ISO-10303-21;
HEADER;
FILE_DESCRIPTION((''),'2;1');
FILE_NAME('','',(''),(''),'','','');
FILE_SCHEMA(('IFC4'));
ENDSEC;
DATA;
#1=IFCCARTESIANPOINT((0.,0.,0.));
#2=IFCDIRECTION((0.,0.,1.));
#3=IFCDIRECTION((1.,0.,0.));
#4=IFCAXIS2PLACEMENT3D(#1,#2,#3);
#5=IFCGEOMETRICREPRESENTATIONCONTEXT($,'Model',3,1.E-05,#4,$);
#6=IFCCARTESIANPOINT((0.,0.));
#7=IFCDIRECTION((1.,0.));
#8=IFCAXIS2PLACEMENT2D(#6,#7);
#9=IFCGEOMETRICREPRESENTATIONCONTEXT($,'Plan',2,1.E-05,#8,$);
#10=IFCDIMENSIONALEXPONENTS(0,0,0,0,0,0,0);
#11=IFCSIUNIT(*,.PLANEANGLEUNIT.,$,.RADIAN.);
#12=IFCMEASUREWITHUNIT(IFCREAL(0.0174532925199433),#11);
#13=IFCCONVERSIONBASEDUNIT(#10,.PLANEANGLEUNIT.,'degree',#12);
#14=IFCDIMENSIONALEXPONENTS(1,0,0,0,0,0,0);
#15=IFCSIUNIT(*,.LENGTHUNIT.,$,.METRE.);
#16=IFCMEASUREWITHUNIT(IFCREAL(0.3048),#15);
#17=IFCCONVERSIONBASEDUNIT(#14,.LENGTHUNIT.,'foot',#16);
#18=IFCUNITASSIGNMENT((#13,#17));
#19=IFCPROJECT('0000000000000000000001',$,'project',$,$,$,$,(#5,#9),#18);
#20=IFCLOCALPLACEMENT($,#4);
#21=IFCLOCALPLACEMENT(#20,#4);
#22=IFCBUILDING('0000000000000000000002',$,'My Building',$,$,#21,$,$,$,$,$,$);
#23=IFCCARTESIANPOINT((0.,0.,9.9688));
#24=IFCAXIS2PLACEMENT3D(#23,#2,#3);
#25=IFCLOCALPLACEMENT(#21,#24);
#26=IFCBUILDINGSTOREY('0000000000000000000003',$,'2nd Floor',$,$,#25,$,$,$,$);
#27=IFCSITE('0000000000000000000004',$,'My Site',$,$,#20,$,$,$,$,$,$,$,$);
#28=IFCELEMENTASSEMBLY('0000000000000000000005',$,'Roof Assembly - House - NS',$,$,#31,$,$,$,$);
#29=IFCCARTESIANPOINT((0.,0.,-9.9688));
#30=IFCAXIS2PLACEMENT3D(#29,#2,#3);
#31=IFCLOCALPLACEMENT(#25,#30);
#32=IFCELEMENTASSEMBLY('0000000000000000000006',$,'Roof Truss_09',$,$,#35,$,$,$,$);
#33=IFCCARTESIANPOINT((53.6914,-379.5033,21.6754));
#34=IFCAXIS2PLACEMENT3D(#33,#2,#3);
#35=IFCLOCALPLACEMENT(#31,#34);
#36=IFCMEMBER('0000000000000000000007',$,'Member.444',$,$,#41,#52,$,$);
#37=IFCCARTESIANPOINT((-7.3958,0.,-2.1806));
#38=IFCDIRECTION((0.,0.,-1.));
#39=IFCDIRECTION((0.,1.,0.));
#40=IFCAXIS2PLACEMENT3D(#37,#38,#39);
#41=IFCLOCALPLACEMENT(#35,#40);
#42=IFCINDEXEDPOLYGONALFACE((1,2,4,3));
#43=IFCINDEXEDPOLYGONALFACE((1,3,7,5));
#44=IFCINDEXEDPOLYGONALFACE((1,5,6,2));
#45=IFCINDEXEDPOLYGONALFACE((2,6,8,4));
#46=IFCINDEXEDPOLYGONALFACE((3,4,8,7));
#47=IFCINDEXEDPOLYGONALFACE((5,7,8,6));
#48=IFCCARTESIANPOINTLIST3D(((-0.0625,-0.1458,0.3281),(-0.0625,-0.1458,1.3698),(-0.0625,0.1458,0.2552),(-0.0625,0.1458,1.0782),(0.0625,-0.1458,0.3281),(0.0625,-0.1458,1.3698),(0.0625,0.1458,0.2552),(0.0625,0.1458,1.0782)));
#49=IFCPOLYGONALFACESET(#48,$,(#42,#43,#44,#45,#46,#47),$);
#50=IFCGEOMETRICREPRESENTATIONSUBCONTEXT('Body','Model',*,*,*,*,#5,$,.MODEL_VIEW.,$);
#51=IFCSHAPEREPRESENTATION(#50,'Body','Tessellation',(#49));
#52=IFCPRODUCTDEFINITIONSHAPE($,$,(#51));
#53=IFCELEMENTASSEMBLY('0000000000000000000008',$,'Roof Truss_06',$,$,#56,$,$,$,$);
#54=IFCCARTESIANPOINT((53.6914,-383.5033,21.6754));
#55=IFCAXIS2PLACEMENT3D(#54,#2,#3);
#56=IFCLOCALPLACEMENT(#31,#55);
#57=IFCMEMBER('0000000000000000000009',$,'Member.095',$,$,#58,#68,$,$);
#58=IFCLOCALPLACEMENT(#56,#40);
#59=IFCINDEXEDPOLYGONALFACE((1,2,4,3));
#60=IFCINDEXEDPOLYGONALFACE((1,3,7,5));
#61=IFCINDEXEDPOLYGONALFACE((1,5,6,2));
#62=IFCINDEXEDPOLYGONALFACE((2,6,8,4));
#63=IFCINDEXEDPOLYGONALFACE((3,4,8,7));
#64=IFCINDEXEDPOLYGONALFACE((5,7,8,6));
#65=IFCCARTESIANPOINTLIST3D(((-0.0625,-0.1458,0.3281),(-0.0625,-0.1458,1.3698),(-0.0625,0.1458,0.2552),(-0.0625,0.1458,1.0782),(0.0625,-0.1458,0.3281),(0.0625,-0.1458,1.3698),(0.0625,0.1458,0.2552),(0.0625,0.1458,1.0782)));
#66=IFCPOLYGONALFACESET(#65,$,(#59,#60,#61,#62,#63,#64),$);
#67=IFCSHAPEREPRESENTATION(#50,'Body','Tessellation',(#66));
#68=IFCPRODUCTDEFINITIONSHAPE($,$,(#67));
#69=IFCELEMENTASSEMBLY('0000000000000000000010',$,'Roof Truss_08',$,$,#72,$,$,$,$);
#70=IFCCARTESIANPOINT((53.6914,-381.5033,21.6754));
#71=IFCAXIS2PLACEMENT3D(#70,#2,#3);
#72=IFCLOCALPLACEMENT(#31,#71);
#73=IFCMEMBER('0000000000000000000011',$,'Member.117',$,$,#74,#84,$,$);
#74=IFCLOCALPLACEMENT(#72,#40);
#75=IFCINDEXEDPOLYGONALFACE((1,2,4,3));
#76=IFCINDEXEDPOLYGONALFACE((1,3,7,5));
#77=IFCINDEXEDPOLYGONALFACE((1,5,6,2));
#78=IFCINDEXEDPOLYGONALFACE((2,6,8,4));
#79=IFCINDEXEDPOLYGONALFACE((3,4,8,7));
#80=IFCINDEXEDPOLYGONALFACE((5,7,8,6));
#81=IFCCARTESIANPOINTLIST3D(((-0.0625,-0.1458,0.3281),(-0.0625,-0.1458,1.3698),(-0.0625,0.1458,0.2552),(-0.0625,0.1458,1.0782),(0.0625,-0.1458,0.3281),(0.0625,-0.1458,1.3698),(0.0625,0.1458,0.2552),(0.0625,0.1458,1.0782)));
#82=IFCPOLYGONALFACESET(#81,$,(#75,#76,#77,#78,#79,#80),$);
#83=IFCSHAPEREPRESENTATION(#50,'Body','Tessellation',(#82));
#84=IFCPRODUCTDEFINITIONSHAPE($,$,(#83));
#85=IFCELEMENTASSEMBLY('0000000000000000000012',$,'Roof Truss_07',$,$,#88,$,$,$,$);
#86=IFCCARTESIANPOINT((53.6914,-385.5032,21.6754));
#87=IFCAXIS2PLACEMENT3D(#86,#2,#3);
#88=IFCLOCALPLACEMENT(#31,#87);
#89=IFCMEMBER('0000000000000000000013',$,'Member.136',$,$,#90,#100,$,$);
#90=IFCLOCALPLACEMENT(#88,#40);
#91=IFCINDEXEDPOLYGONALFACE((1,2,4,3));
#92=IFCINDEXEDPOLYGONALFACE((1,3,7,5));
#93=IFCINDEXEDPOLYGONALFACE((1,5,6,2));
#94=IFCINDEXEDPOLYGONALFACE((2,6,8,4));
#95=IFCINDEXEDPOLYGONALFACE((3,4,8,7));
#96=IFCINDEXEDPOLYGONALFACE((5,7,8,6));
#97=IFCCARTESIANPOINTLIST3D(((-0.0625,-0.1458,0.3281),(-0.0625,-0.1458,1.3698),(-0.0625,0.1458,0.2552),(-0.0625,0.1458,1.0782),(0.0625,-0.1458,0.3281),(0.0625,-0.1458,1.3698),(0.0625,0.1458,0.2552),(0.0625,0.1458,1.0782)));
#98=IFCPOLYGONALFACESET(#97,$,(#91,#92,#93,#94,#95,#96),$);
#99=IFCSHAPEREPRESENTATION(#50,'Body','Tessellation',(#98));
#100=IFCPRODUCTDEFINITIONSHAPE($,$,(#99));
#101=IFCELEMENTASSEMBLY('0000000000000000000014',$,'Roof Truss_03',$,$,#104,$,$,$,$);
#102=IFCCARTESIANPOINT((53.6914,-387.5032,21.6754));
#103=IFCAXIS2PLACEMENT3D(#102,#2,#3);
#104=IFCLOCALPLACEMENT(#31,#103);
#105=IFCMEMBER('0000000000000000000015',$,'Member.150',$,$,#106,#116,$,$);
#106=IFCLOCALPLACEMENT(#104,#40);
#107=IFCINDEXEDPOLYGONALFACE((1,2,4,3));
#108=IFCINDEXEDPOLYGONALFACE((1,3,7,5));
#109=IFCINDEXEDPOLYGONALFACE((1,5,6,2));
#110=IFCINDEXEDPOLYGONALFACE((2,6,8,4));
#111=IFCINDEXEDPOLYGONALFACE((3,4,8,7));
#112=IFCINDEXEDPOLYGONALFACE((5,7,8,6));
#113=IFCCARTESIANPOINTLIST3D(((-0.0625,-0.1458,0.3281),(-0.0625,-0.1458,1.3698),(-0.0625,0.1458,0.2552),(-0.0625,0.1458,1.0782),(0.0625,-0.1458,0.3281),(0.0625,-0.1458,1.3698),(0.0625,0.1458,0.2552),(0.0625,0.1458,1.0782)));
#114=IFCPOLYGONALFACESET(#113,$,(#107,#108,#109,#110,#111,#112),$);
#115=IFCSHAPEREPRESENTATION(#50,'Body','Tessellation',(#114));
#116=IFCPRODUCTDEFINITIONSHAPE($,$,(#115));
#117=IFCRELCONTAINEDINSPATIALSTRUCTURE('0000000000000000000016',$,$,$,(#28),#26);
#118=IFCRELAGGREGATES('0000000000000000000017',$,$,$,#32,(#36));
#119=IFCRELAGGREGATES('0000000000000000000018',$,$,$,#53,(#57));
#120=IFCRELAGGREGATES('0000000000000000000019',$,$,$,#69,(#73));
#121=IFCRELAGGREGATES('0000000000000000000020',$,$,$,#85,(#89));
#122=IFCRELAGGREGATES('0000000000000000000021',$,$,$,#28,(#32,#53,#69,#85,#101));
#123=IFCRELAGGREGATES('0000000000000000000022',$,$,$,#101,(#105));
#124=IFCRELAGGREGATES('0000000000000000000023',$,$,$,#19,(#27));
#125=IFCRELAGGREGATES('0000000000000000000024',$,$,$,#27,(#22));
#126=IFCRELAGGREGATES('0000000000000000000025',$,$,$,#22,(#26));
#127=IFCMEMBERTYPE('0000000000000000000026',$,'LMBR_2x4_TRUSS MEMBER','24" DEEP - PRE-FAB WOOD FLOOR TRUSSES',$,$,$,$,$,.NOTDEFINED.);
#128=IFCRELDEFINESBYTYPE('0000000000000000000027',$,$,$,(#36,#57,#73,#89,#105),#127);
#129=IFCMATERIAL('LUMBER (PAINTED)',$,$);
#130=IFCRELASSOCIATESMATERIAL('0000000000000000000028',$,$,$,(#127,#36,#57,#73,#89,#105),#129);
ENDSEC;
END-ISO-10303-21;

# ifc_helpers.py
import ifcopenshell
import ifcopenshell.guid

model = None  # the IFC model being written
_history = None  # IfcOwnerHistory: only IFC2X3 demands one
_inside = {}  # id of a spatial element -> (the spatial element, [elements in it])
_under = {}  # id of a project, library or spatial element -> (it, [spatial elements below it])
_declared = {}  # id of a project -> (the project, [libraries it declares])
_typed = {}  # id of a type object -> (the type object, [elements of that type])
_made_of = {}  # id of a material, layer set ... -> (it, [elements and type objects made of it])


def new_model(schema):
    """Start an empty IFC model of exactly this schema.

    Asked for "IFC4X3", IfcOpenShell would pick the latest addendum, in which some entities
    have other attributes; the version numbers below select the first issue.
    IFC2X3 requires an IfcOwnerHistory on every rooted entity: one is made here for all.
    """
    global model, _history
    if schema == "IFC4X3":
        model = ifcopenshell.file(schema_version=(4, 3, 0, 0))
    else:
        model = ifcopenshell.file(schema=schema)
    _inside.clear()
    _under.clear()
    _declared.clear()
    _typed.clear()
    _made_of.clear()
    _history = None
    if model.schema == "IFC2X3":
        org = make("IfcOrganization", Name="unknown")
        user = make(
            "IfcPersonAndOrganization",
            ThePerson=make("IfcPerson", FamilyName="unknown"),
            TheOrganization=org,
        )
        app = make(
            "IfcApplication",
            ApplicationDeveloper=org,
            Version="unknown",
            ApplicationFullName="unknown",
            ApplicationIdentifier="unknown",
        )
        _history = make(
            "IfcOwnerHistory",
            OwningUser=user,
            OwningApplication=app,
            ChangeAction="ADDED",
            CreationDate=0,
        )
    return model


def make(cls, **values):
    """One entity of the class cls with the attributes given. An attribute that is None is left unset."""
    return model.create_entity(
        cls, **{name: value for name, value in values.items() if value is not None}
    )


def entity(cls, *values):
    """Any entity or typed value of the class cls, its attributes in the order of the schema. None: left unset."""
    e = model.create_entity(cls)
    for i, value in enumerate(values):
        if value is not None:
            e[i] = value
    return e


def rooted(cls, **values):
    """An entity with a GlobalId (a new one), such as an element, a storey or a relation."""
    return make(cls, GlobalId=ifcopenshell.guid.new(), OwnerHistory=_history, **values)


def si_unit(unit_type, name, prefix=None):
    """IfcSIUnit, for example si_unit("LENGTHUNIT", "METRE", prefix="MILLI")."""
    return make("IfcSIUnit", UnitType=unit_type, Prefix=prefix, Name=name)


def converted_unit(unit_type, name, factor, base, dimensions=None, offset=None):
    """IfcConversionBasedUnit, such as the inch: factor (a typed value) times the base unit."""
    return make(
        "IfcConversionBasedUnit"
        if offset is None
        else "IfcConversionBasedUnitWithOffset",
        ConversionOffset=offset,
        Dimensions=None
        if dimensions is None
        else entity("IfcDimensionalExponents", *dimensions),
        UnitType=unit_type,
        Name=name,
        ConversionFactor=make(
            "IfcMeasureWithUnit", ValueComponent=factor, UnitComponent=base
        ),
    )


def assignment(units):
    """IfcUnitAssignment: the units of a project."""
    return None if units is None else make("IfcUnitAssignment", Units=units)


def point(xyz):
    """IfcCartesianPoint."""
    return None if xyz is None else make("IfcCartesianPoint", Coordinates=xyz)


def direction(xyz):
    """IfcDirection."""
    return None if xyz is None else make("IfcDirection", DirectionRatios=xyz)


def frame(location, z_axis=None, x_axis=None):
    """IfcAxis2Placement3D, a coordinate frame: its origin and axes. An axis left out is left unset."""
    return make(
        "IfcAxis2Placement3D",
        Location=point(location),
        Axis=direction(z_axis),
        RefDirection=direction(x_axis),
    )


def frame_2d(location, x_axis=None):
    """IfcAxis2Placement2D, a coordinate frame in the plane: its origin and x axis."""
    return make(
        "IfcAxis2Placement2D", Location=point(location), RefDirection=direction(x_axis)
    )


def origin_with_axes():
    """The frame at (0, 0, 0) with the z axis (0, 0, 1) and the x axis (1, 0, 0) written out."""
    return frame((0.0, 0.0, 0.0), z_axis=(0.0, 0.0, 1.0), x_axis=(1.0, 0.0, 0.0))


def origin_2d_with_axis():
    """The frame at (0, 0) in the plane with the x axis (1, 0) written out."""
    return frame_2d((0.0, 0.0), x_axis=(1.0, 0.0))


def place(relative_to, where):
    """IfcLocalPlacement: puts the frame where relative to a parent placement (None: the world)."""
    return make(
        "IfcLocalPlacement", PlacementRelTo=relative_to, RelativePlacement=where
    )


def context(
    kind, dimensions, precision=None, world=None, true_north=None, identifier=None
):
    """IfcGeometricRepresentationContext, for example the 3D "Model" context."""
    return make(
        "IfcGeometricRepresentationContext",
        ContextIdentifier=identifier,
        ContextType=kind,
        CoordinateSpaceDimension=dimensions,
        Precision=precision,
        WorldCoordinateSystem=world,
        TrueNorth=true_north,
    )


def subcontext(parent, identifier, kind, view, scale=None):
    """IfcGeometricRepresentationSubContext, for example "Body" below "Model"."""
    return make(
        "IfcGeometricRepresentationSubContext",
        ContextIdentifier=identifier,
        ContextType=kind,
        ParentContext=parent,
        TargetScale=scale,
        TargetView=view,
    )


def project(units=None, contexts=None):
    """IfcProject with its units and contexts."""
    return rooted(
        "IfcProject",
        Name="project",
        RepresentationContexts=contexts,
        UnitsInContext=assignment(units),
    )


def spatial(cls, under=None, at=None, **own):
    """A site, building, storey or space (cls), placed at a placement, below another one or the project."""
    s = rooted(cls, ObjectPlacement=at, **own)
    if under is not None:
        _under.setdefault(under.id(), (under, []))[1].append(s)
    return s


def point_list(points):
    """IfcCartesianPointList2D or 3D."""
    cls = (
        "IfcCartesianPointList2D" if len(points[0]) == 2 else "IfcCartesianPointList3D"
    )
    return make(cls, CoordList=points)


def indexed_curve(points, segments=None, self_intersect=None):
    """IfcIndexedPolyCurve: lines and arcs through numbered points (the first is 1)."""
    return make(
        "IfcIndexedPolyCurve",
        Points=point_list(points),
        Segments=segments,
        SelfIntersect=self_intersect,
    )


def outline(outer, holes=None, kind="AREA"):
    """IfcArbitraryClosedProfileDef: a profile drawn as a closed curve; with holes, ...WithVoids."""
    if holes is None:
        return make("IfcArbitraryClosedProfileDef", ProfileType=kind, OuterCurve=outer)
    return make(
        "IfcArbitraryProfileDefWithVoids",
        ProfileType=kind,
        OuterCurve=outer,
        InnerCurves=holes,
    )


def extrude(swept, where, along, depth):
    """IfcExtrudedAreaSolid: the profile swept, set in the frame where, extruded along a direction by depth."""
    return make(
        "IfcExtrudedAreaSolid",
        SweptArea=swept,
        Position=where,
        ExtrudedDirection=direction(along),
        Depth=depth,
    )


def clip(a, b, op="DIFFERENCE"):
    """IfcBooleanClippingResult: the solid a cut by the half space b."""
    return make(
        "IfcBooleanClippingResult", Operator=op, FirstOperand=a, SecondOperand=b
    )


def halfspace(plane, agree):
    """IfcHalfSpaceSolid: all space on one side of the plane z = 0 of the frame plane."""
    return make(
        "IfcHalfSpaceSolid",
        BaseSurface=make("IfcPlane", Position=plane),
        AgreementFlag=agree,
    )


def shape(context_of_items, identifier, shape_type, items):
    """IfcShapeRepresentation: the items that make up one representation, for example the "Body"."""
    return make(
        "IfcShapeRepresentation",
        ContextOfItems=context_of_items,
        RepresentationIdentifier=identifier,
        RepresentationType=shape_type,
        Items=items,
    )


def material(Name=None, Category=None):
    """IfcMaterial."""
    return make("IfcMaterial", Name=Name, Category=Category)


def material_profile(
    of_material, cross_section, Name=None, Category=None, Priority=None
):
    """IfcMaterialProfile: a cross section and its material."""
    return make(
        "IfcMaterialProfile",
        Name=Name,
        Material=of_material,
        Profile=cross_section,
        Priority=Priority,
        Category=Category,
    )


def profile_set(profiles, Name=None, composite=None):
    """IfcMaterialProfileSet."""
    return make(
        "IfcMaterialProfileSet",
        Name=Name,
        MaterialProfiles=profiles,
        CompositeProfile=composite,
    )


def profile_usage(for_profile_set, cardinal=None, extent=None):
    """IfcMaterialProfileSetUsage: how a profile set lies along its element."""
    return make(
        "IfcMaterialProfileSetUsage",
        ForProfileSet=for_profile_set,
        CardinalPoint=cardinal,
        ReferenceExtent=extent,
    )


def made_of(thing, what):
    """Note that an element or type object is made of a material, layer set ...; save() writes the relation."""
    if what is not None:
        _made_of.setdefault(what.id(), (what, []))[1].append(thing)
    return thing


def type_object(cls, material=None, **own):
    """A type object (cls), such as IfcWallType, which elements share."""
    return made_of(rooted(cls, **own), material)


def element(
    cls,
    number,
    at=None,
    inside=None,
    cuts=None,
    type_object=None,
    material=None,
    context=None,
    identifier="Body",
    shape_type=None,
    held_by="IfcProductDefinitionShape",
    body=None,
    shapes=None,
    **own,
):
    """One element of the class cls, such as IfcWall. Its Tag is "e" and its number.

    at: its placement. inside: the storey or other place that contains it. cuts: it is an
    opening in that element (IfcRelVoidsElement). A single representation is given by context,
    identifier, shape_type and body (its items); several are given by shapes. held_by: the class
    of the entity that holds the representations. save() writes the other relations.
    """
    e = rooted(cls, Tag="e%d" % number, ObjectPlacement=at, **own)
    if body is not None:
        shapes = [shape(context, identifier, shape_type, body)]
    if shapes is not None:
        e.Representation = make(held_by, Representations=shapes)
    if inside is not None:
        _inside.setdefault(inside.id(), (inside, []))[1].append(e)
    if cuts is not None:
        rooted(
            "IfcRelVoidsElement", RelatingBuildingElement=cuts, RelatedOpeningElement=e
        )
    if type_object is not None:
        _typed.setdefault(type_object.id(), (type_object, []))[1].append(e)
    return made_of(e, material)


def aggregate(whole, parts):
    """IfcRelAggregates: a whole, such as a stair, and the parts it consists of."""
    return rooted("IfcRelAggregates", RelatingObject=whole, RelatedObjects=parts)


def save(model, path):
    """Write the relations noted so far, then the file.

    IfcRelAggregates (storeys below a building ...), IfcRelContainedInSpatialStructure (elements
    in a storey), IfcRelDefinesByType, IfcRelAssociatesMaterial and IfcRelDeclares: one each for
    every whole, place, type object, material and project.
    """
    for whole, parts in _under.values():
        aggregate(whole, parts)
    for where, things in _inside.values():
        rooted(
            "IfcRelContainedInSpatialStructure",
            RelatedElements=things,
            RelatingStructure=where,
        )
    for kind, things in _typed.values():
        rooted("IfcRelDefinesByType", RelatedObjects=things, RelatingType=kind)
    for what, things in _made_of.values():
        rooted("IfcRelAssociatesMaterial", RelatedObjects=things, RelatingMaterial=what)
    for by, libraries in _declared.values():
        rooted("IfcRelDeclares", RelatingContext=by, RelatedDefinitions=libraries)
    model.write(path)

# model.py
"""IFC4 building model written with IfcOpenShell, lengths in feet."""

from ifc_helpers import new_model, entity, si_unit, converted_unit, frame, origin_with_axes, origin_2d_with_axis, place, context, subcontext, project, spatial, indexed_curve, outline, extrude, clip, halfspace, material, material_profile, profile_set, profile_usage, type_object, element, aggregate, save


model = new_model("IFC4")

# Units and contexts
model_context = context("Model", 3, precision=1e-05, world=origin_with_axes())
plan_context = context("Plan", 2, precision=1e-05, world=origin_2d_with_axis())
body_context = subcontext(model_context, "Body", "Model", "MODEL_VIEW")
ifc_project = project(units=[converted_unit("PLANEANGLEUNIT", "degree", entity("IfcReal", 0.0174532925199433), si_unit("PLANEANGLEUNIT", "RADIAN"), dimensions=[0, 0, 0, 0, 0, 0, 0]), converted_unit("LENGTHUNIT", "foot", entity("IfcReal", 0.3048), si_unit("LENGTHUNIT", "METRE"), dimensions=[1, 0, 0, 0, 0, 0, 0])], contexts=[model_context, plan_context])

# Site, building, storey
site_placement = place(None, origin_with_axes())
site = spatial("IfcSite", under=ifc_project, at=site_placement, Name="My Site")
building_placement = place(site_placement, origin_with_axes())
building = spatial("IfcBuilding", under=site, at=building_placement, Name="My Building")
storey_placement = place(building_placement, frame((0.0, 0.0, 9.9688), z_axis=(0.0, 0.0, 1.0), x_axis=(1.0, 0.0, 0.0)))
storey = spatial("IfcBuildingStorey", under=building, at=storey_placement, Name="2nd Floor")

# Element assemblies, members
assembly_1_placement = place(storey_placement, frame((0.0, 0.0, -9.9688), z_axis=(0.0, 0.0, 1.0), x_axis=(1.0, 0.0, 0.0)))
assembly_1 = element("IfcElementAssembly", 1, at=assembly_1_placement, inside=storey, Name="Roof Assembly - House - NS")
assembly_2_placement = place(assembly_1_placement, frame((53.6914, -379.5033, 21.6754), z_axis=(0.0, 0.0, 1.0), x_axis=(1.0, 0.0, 0.0)))
assembly_2 = element("IfcElementAssembly", 2, at=assembly_2_placement, Name="Roof Truss_09")
ifc_material = material(Name="LUMBER (PAINTED)")
ifc_material_profile_1 = material_profile(ifc_material, outline(indexed_curve([(-0.0625, -0.1458), (0.0625, -0.1458), (0.0625, 0.1458), (-0.0625, 0.1458), (-0.0625, -0.1458)])))
ifc_profile_set_1 = profile_set([ifc_material_profile_1])
ifc_profile_usage_1 = profile_usage(ifc_profile_set_1)
member_type_1 = type_object("IfcMemberType", Name="LMBR_2x4_TRUSS MEMBER", Description="24\" DEEP - PRE-FAB WOOD FLOOR TRUSSES", PredefinedType="NOTDEFINED", material=ifc_profile_set_1)
member_1_placement = place(assembly_2_placement, frame((-7.3958, 0.0, -2.1806), z_axis=(0.0, 0.0, -1.0), x_axis=(0.0, 1.0, 0.0)))
member_1 = element("IfcMember", 3, at=member_1_placement, type_object=member_type_1, material=ifc_profile_usage_1, Name="Member.444", context=body_context, shape_type="Clipping", body=[
    clip(clip(extrude(outline(indexed_curve([(-0.0625, -0.1458), (0.0625, -0.1458), (0.0625, 0.1458), (-0.0625, 0.1458), (-0.0625, -0.1458)])), origin_with_axes(), (0.0, 0.0, 1.0), 1.3698), halfspace(frame((0.0, 7.5424, -1.5944), z_axis=(0.0, -0.242599, -0.970127), x_axis=(-1.0, 0.000001, 0.0)), False)), halfspace(frame((397.5032, -0.1458, 1.3698), z_axis=(0.0, 0.707107, 0.707107), x_axis=(1.0, 0.0, 0.0)), False)),
])
aggregate(assembly_2, [member_1])
assembly_3_placement = place(assembly_1_placement, frame((53.6914, -383.5033, 21.6754), z_axis=(0.0, 0.0, 1.0), x_axis=(1.0, 0.0, 0.0)))
assembly_3 = element("IfcElementAssembly", 4, at=assembly_3_placement, Name="Roof Truss_06")
ifc_profile_usage_2 = profile_usage(ifc_profile_set_1)
member_2_placement = place(assembly_3_placement, frame((-7.3958, 0.0, -2.1806), z_axis=(0.0, 0.0, -1.0), x_axis=(0.0, 1.0, 0.0)))
member_2 = element("IfcMember", 5, at=member_2_placement, type_object=member_type_1, material=ifc_profile_usage_2, Name="Member.095", context=body_context, shape_type="Clipping", body=[
    clip(clip(extrude(outline(indexed_curve([(-0.0625, -0.1458), (0.0625, -0.1458), (0.0625, 0.1458), (-0.0625, 0.1458), (-0.0625, -0.1458)])), origin_with_axes(), (0.0, 0.0, 1.0), 1.3698), halfspace(frame((0.0, 7.5424, -1.5944), z_axis=(0.0, -0.242599, -0.970127), x_axis=(-1.0, 0.000001, 0.0)), False)), halfspace(frame((397.5032, -0.1458, 1.3698), z_axis=(0.0, 0.707107, 0.707107), x_axis=(1.0, 0.0, 0.0)), False)),
])
aggregate(assembly_3, [member_2])
assembly_4_placement = place(assembly_1_placement, frame((53.6914, -381.5033, 21.6754), z_axis=(0.0, 0.0, 1.0), x_axis=(1.0, 0.0, 0.0)))
assembly_4 = element("IfcElementAssembly", 6, at=assembly_4_placement, Name="Roof Truss_08")
ifc_profile_usage_3 = profile_usage(ifc_profile_set_1)
member_3_placement = place(assembly_4_placement, frame((-7.3958, 0.0, -2.1806), z_axis=(0.0, 0.0, -1.0), x_axis=(0.0, 1.0, 0.0)))
member_3 = element("IfcMember", 7, at=member_3_placement, type_object=member_type_1, material=ifc_profile_usage_3, Name="Member.117", context=body_context, shape_type="Clipping", body=[
    clip(clip(extrude(outline(indexed_curve([(-0.0625, -0.1458), (0.0625, -0.1458), (0.0625, 0.1458), (-0.0625, 0.1458), (-0.0625, -0.1458)])), origin_with_axes(), (0.0, 0.0, 1.0), 1.3698), halfspace(frame((0.0, 7.5424, -1.5944), z_axis=(0.0, -0.242599, -0.970127), x_axis=(-1.0, 0.000001, 0.0)), False)), halfspace(frame((397.5032, -0.1458, 1.3698), z_axis=(0.0, 0.707107, 0.707107), x_axis=(1.0, 0.0, 0.0)), False)),
])
aggregate(assembly_4, [member_3])
assembly_5_placement = place(assembly_1_placement, frame((53.6914, -385.5032, 21.6754), z_axis=(0.0, 0.0, 1.0), x_axis=(1.0, 0.0, 0.0)))
assembly_5 = element("IfcElementAssembly", 8, at=assembly_5_placement, Name="Roof Truss_07")
ifc_profile_usage_4 = profile_usage(ifc_profile_set_1)
member_4_placement = place(assembly_5_placement, frame((-7.3958, 0.0, -2.1806), z_axis=(0.0, 0.0, -1.0), x_axis=(0.0, 1.0, 0.0)))
member_4 = element("IfcMember", 9, at=member_4_placement, type_object=member_type_1, material=ifc_profile_usage_4, Name="Member.136", context=body_context, shape_type="Clipping", body=[
    clip(clip(extrude(outline(indexed_curve([(-0.0625, -0.1458), (0.0625, -0.1458), (0.0625, 0.1458), (-0.0625, 0.1458), (-0.0625, -0.1458)])), origin_with_axes(), (0.0, 0.0, 1.0), 1.3698), halfspace(frame((0.0, 7.5424, -1.5944), z_axis=(0.0, -0.242599, -0.970127), x_axis=(-1.0, 0.000001, 0.0)), False)), halfspace(frame((397.5032, -0.1458, 1.3698), z_axis=(0.0, 0.707107, 0.707107), x_axis=(1.0, 0.0, 0.0)), False)),
])
aggregate(assembly_5, [member_4])
assembly_6_placement = place(assembly_1_placement, frame((53.6914, -387.5032, 21.6754), z_axis=(0.0, 0.0, 1.0), x_axis=(1.0, 0.0, 0.0)))
assembly_6 = element("IfcElementAssembly", 10, at=assembly_6_placement, Name="Roof Truss_03")
aggregate(assembly_1, [assembly_2, assembly_3, assembly_4, assembly_5, assembly_6])
ifc_profile_usage_5 = profile_usage(ifc_profile_set_1)
member_5_placement = place(assembly_6_placement, frame((-7.3958, 0.0, -2.1806), z_axis=(0.0, 0.0, -1.0), x_axis=(0.0, 1.0, 0.0)))
member_5 = element("IfcMember", 11, at=member_5_placement, type_object=member_type_1, material=ifc_profile_usage_5, Name="Member.150", context=body_context, shape_type="Clipping", body=[
    clip(clip(extrude(outline(indexed_curve([(-0.0625, -0.1458), (0.0625, -0.1458), (0.0625, 0.1458), (-0.0625, 0.1458), (-0.0625, -0.1458)])), origin_with_axes(), (0.0, 0.0, 1.0), 1.3698), halfspace(frame((0.0, 7.5424, -1.5944), z_axis=(0.0, -0.242599, -0.970127), x_axis=(-1.0, 0.000001, 0.0)), False)), halfspace(frame((397.5032, -0.1458, 1.3698), z_axis=(0.0, 0.707107, 0.707107), x_axis=(1.0, 0.0, 0.0)), False)),
])
aggregate(assembly_6, [member_5])

save(model, "model.ifc")
